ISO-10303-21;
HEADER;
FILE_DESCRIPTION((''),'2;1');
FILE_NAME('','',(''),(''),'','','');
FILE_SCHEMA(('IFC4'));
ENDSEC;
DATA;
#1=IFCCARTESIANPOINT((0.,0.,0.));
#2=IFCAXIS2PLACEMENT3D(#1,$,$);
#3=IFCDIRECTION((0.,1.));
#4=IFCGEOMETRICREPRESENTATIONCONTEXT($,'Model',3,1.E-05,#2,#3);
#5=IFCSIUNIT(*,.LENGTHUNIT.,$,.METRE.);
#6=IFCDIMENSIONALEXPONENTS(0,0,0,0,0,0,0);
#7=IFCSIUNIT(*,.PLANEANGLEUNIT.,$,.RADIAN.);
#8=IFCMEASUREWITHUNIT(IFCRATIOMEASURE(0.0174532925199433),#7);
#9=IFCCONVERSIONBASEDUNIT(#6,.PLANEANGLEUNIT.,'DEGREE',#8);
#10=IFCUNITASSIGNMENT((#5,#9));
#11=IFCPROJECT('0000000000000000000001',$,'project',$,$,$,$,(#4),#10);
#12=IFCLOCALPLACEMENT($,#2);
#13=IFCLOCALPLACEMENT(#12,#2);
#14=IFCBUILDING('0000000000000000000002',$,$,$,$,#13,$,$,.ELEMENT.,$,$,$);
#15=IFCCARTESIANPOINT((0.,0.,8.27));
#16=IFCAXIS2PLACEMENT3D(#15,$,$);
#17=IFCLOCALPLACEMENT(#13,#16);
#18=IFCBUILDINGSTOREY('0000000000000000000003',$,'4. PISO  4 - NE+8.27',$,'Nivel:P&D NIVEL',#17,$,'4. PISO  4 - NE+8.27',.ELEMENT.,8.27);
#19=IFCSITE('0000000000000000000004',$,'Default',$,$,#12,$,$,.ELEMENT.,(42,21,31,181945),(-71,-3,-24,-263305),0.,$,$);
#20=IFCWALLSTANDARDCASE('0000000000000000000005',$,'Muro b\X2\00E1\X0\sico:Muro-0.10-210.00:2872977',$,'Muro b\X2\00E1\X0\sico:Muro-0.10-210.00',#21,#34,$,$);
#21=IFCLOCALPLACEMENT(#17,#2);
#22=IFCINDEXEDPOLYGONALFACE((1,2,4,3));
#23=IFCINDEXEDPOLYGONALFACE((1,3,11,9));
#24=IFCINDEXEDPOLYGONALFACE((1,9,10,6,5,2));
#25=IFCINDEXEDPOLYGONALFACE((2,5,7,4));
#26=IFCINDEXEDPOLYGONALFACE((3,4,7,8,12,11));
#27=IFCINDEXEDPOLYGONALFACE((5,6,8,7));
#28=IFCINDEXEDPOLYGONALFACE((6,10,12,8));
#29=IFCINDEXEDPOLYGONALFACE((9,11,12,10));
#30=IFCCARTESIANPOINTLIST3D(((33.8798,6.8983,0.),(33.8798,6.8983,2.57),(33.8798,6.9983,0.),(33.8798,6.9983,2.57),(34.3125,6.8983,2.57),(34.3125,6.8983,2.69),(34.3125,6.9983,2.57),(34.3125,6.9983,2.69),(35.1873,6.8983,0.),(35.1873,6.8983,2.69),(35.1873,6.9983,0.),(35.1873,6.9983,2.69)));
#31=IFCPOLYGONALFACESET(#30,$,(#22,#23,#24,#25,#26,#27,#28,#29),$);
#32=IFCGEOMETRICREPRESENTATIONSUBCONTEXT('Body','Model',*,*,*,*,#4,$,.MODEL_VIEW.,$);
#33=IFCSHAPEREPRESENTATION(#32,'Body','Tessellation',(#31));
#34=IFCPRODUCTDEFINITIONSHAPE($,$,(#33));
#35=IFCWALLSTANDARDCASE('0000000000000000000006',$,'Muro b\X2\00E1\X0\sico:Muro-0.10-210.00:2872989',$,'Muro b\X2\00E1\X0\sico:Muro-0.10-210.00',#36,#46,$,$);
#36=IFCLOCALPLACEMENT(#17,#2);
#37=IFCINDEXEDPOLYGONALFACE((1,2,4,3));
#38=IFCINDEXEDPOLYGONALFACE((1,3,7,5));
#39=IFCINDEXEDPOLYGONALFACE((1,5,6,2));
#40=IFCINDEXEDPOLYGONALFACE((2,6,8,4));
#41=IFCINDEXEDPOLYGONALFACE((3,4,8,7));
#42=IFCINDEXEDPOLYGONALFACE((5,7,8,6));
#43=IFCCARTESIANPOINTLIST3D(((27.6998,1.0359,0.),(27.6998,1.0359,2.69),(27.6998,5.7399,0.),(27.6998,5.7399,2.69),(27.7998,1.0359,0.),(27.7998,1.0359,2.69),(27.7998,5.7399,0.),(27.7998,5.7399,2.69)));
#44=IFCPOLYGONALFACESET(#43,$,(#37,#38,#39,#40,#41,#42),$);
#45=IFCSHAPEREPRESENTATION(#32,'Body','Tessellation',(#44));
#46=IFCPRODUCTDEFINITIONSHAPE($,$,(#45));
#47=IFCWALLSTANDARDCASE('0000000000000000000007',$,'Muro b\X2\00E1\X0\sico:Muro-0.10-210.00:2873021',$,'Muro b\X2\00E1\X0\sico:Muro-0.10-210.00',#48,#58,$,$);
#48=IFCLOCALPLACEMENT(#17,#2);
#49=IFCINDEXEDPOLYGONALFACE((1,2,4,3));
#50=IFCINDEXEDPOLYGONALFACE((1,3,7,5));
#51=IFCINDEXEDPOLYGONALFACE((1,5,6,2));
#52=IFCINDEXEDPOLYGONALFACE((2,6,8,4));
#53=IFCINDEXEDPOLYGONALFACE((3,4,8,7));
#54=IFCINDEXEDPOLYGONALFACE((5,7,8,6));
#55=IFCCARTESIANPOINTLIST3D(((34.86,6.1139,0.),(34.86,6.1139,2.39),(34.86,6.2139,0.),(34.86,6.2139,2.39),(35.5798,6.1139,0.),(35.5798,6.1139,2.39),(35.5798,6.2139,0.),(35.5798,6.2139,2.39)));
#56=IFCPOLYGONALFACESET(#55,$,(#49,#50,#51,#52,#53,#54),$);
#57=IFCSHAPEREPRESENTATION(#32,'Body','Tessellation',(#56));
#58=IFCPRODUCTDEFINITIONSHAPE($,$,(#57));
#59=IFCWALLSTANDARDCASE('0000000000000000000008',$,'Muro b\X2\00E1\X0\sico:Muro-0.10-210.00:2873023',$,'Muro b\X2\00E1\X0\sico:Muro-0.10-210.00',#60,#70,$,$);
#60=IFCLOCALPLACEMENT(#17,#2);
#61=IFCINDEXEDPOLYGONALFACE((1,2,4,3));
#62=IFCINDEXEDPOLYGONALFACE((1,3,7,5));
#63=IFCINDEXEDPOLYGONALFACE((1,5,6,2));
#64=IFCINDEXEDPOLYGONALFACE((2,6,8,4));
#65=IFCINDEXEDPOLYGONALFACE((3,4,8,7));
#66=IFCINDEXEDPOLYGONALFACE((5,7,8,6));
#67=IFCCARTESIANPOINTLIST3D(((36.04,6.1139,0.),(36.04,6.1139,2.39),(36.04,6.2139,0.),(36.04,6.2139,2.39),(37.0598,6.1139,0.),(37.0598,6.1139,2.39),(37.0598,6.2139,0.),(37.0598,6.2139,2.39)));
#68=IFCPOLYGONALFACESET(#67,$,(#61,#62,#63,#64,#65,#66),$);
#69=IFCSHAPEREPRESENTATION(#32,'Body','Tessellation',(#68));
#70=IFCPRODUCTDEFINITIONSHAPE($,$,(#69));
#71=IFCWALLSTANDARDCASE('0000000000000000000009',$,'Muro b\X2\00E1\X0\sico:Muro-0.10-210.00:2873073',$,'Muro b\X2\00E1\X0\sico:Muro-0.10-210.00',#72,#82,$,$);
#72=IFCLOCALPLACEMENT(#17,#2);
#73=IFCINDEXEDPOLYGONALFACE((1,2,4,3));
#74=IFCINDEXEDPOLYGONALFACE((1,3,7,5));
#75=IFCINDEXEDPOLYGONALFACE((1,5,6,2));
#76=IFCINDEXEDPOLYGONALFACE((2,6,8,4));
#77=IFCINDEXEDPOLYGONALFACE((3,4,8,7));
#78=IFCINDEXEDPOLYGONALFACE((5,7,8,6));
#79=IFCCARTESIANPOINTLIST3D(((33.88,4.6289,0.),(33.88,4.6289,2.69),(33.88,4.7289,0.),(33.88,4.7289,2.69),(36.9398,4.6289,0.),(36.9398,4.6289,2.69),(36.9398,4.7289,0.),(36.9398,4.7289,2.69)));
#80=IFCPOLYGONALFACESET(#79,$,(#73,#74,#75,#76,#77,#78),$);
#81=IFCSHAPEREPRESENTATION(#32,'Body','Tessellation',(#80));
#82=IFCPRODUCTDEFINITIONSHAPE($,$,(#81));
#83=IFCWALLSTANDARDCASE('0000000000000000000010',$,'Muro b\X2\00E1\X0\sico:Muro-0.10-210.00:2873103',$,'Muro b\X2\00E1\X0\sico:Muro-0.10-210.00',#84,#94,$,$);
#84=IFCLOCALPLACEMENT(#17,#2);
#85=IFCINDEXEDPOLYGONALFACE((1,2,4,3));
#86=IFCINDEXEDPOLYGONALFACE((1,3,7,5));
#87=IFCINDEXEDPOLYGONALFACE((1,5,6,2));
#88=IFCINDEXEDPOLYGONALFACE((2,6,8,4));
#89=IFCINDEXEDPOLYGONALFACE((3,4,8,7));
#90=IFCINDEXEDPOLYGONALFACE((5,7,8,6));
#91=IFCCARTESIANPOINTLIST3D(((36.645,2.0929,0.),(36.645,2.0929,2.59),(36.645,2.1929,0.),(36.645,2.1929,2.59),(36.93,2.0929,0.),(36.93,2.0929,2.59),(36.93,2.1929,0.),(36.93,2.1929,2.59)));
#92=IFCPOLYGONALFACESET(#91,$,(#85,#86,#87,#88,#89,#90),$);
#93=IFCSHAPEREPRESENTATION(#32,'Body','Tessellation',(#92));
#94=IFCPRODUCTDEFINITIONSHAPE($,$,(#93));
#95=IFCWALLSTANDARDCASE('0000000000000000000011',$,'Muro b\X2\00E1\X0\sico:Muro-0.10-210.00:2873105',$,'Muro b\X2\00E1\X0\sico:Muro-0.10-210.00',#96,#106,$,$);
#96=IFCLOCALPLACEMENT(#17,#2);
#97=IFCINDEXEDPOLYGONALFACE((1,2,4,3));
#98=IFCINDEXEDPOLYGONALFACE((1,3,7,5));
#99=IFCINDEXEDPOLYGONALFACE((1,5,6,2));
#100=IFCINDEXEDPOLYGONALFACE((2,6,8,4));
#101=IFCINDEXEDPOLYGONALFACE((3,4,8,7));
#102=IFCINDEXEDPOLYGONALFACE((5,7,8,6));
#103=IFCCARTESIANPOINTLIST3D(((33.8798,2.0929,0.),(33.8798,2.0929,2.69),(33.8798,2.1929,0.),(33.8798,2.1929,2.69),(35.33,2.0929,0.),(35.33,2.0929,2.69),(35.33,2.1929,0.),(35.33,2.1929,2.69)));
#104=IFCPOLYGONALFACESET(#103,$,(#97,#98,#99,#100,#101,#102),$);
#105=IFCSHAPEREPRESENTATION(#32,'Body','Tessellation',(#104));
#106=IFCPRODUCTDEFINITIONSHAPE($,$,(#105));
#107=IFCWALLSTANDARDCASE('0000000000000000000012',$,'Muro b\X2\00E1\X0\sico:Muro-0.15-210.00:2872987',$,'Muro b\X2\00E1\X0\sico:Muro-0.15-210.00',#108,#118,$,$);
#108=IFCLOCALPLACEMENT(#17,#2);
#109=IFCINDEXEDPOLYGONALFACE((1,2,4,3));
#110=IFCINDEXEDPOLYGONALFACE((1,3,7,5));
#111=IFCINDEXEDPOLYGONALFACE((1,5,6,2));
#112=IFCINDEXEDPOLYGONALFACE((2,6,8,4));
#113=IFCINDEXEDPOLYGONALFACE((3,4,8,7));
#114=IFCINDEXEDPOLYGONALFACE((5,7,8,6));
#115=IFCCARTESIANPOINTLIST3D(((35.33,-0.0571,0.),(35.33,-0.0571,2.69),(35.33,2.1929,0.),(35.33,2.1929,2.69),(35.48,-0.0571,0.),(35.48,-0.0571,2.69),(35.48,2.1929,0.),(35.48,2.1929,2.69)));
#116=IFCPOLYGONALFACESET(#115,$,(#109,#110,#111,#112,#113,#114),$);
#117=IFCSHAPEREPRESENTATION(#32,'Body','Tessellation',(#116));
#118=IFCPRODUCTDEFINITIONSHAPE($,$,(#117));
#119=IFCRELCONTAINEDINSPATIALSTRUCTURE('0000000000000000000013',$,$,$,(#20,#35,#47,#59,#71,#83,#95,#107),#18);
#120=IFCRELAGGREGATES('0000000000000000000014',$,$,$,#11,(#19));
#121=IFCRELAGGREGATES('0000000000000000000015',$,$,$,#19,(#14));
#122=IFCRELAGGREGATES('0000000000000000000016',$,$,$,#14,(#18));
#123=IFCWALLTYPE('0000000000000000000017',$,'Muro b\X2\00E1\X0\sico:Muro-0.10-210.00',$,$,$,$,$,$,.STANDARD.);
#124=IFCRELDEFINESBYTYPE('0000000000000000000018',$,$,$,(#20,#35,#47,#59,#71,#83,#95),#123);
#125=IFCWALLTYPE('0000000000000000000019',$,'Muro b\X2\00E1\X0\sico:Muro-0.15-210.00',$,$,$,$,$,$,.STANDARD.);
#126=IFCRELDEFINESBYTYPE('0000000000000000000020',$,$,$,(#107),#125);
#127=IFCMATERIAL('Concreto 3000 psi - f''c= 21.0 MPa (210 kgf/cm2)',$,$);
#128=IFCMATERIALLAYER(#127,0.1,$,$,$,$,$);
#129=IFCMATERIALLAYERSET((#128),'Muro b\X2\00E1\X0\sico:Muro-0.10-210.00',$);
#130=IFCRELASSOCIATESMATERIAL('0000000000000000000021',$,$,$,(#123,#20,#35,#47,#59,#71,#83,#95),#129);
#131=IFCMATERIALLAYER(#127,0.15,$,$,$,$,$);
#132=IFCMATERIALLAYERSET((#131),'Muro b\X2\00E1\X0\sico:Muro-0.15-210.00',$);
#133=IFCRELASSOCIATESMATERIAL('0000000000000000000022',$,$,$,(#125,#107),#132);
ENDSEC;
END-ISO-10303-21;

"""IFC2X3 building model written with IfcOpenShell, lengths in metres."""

from ifc_helpers import new_model, entity, si_unit, converted_unit, direction, frame, frame_2d, origin, place, context, subcontext, project, spatial, polyline, rectangle, extrude, clip, bounded_halfspace, material, layer, layer_set, layer_usage, type_object, element, save


model = new_model("IFC2X3")

# Units and contexts
model_context = context("Model", 3, precision=1e-05, world=origin(), true_north=direction((0.0, 1.0)))
body_context = subcontext(model_context, "Body", "Model", "MODEL_VIEW")
ifc_project = project(units=[si_unit("LENGTHUNIT", "METRE"), converted_unit("PLANEANGLEUNIT", "DEGREE", entity("IfcRatioMeasure", 0.0174532925199433), si_unit("PLANEANGLEUNIT", "RADIAN"), dimensions=[0, 0, 0, 0, 0, 0, 0])], contexts=[model_context])

# Site, building, storey
site_placement = place(None, origin())
site = spatial("IfcSite", under=ifc_project, at=site_placement, Name="Default", CompositionType="ELEMENT", RefLatitude=(42, 21, 31, 181945), RefLongitude=(-71, -3, -24, -263305), RefElevation=0.0)
building_placement = place(site_placement, origin())
building = spatial("IfcBuilding", under=site, at=building_placement, CompositionType="ELEMENT")
storey_placement = place(building_placement, frame((0.0, 0.0, 8.27)))
storey = spatial("IfcBuildingStorey", under=building, at=storey_placement, Name="4. PISO  4 - NE+8.27", ObjectType="Nivel:P&D NIVEL", LongName="4. PISO  4 - NE+8.27", CompositionType="ELEMENT", Elevation=8.27)

# Shared definitions
ifc_material = material(Name="Concreto 3000 psi - f'c= 21.0 MPa (210 kgf/cm2)")

# Walls
ifc_layer_1 = layer(ifc_material, 0.1)
ifc_layer_set_1 = layer_set([ifc_layer_1], Name="Muro básico:Muro-0.10-210.00")
ifc_layer_usage_1 = layer_usage(ifc_layer_set_1, "AXIS2", "POSITIVE", -0.05)
wall_type_1 = type_object("IfcWallType", Name="Muro básico:Muro-0.10-210.00", PredefinedType="STANDARD", material=ifc_layer_set_1)
wall_1_placement = place(storey_placement, frame((33.8798, 6.9483, 0.0)))
element("IfcWallStandardCase", 1, at=wall_1_placement, inside=storey, type_object=wall_type_1, material=ifc_layer_usage_1, Name="Muro básico:Muro-0.10-210.00:2872977", ObjectType="Muro básico:Muro-0.10-210.00", context=body_context, shape_type="Clipping", body=[
    clip(clip(extrude(rectangle(XDim=1.3075, YDim=0.1, at=frame_2d((0.6538, 0.0), x_axis=(-1.0, 0.0))), origin(), (0.0, 0.0, 1.0), 2.69), bounded_halfspace(frame((0.4327, -0.05, 2.57), z_axis=(0.0, 0.0, -1.0), x_axis=(0.0, -1.0, 0.0)), True, frame((0.4327, -0.05, 2.57), z_axis=(0.0, 0.0, -1.0), x_axis=(0.0, -1.0, 0.0)), polyline([(0.0, 0.0), (0.0, 0.4327), (-0.1, 0.4327), (-0.1, 0.0), (0.0, 0.0)]))), bounded_halfspace(frame((0.4327, 0.05, 2.57), z_axis=(1.0, 0.0, 0.0), x_axis=(0.0, 0.0, 1.0)), True, frame((0.4327, 0.05, 2.57), z_axis=(1.0, 0.0, 0.0), x_axis=(0.0, 0.0, 1.0)), polyline([(0.0, 0.0), (0.12, 0.0), (0.12, 0.1), (0.0, 0.1), (0.0, 0.0)]))),
])
wall_2_placement = place(storey_placement, frame((27.7498, 1.0359, 0.0), z_axis=(0.0, 0.0, 1.0), x_axis=(0.0, 1.0, 0.0)))
element("IfcWallStandardCase", 2, at=wall_2_placement, inside=storey, type_object=wall_type_1, material=ifc_layer_usage_1, Name="Muro básico:Muro-0.10-210.00:2872989", ObjectType="Muro básico:Muro-0.10-210.00", context=body_context, shape_type="SweptSolid", body=[
    extrude(rectangle(XDim=4.704, YDim=0.1, at=frame_2d((2.352, 0.0), x_axis=(-1.0, 0.0))), origin(), (0.0, 0.0, 1.0), 2.69),
])
wall_3_placement = place(storey_placement, frame((34.86, 6.1639, 0.0)))
element("IfcWallStandardCase", 3, at=wall_3_placement, inside=storey, type_object=wall_type_1, material=ifc_layer_usage_1, Name="Muro básico:Muro-0.10-210.00:2873021", ObjectType="Muro básico:Muro-0.10-210.00", context=body_context, shape_type="SweptSolid", body=[
    extrude(rectangle(XDim=0.7198, YDim=0.1, at=frame_2d((0.3599, 0.0), x_axis=(-1.0, 0.0))), origin(), (0.0, 0.0, 1.0), 2.39),
])
wall_4_placement = place(storey_placement, frame((36.04, 6.1639, 0.0)))
element("IfcWallStandardCase", 4, at=wall_4_placement, inside=storey, type_object=wall_type_1, material=ifc_layer_usage_1, Name="Muro básico:Muro-0.10-210.00:2873023", ObjectType="Muro básico:Muro-0.10-210.00", context=body_context, shape_type="SweptSolid", body=[
    extrude(rectangle(XDim=1.0198, YDim=0.1, at=frame_2d((0.5099, 0.0), x_axis=(-1.0, 0.0))), origin(), (0.0, 0.0, 1.0), 2.39),
])
wall_5_placement = place(storey_placement, frame((33.88, 4.6789, 0.0)))
element("IfcWallStandardCase", 5, at=wall_5_placement, inside=storey, type_object=wall_type_1, material=ifc_layer_usage_1, Name="Muro básico:Muro-0.10-210.00:2873073", ObjectType="Muro básico:Muro-0.10-210.00", context=body_context, shape_type="SweptSolid", body=[
    extrude(rectangle(XDim=3.0598, YDim=0.1, at=frame_2d((1.5299, 0.0), x_axis=(-1.0, 0.0))), origin(), (0.0, 0.0, 1.0), 2.69),
])
wall_6_placement = place(storey_placement, frame((36.645, 2.1429, 0.0)))
element("IfcWallStandardCase", 6, at=wall_6_placement, inside=storey, type_object=wall_type_1, material=ifc_layer_usage_1, Name="Muro básico:Muro-0.10-210.00:2873103", ObjectType="Muro básico:Muro-0.10-210.00", context=body_context, shape_type="SweptSolid", body=[
    extrude(rectangle(XDim=0.285, YDim=0.1, at=frame_2d((0.1425, 0.0), x_axis=(-1.0, 0.0))), origin(), (0.0, 0.0, 1.0), 2.59),
])
wall_7_placement = place(storey_placement, frame((33.8798, 2.1429, 0.0)))
element("IfcWallStandardCase", 7, at=wall_7_placement, inside=storey, type_object=wall_type_1, material=ifc_layer_usage_1, Name="Muro básico:Muro-0.10-210.00:2873105", ObjectType="Muro básico:Muro-0.10-210.00", context=body_context, shape_type="SweptSolid", body=[
    extrude(rectangle(XDim=1.4502, YDim=0.1, at=frame_2d((0.7251, 0.0), x_axis=(-1.0, 0.0))), origin(), (0.0, 0.0, 1.0), 2.69),
])
ifc_layer_2 = layer(ifc_material, 0.15)
ifc_layer_set_2 = layer_set([ifc_layer_2], Name="Muro básico:Muro-0.15-210.00")
ifc_layer_usage_2 = layer_usage(ifc_layer_set_2, "AXIS2", "POSITIVE", -0.075)
wall_type_2 = type_object("IfcWallType", Name="Muro básico:Muro-0.15-210.00", PredefinedType="STANDARD", material=ifc_layer_set_2)
wall_8_placement = place(storey_placement, frame((35.405, -0.0571, 0.0), z_axis=(0.0, 0.0, 1.0), x_axis=(0.0, 1.0, 0.0)))
element("IfcWallStandardCase", 8, at=wall_8_placement, inside=storey, type_object=wall_type_2, material=ifc_layer_usage_2, Name="Muro básico:Muro-0.15-210.00:2872987", ObjectType="Muro básico:Muro-0.15-210.00", context=body_context, shape_type="SweptSolid", body=[
    extrude(rectangle(XDim=2.25, YDim=0.15, at=frame_2d((1.125, 0.0), x_axis=(-1.0, 0.0))), origin(), (0.0, 0.0, 1.0), 2.69),
])

save(model, "model.ifc")
